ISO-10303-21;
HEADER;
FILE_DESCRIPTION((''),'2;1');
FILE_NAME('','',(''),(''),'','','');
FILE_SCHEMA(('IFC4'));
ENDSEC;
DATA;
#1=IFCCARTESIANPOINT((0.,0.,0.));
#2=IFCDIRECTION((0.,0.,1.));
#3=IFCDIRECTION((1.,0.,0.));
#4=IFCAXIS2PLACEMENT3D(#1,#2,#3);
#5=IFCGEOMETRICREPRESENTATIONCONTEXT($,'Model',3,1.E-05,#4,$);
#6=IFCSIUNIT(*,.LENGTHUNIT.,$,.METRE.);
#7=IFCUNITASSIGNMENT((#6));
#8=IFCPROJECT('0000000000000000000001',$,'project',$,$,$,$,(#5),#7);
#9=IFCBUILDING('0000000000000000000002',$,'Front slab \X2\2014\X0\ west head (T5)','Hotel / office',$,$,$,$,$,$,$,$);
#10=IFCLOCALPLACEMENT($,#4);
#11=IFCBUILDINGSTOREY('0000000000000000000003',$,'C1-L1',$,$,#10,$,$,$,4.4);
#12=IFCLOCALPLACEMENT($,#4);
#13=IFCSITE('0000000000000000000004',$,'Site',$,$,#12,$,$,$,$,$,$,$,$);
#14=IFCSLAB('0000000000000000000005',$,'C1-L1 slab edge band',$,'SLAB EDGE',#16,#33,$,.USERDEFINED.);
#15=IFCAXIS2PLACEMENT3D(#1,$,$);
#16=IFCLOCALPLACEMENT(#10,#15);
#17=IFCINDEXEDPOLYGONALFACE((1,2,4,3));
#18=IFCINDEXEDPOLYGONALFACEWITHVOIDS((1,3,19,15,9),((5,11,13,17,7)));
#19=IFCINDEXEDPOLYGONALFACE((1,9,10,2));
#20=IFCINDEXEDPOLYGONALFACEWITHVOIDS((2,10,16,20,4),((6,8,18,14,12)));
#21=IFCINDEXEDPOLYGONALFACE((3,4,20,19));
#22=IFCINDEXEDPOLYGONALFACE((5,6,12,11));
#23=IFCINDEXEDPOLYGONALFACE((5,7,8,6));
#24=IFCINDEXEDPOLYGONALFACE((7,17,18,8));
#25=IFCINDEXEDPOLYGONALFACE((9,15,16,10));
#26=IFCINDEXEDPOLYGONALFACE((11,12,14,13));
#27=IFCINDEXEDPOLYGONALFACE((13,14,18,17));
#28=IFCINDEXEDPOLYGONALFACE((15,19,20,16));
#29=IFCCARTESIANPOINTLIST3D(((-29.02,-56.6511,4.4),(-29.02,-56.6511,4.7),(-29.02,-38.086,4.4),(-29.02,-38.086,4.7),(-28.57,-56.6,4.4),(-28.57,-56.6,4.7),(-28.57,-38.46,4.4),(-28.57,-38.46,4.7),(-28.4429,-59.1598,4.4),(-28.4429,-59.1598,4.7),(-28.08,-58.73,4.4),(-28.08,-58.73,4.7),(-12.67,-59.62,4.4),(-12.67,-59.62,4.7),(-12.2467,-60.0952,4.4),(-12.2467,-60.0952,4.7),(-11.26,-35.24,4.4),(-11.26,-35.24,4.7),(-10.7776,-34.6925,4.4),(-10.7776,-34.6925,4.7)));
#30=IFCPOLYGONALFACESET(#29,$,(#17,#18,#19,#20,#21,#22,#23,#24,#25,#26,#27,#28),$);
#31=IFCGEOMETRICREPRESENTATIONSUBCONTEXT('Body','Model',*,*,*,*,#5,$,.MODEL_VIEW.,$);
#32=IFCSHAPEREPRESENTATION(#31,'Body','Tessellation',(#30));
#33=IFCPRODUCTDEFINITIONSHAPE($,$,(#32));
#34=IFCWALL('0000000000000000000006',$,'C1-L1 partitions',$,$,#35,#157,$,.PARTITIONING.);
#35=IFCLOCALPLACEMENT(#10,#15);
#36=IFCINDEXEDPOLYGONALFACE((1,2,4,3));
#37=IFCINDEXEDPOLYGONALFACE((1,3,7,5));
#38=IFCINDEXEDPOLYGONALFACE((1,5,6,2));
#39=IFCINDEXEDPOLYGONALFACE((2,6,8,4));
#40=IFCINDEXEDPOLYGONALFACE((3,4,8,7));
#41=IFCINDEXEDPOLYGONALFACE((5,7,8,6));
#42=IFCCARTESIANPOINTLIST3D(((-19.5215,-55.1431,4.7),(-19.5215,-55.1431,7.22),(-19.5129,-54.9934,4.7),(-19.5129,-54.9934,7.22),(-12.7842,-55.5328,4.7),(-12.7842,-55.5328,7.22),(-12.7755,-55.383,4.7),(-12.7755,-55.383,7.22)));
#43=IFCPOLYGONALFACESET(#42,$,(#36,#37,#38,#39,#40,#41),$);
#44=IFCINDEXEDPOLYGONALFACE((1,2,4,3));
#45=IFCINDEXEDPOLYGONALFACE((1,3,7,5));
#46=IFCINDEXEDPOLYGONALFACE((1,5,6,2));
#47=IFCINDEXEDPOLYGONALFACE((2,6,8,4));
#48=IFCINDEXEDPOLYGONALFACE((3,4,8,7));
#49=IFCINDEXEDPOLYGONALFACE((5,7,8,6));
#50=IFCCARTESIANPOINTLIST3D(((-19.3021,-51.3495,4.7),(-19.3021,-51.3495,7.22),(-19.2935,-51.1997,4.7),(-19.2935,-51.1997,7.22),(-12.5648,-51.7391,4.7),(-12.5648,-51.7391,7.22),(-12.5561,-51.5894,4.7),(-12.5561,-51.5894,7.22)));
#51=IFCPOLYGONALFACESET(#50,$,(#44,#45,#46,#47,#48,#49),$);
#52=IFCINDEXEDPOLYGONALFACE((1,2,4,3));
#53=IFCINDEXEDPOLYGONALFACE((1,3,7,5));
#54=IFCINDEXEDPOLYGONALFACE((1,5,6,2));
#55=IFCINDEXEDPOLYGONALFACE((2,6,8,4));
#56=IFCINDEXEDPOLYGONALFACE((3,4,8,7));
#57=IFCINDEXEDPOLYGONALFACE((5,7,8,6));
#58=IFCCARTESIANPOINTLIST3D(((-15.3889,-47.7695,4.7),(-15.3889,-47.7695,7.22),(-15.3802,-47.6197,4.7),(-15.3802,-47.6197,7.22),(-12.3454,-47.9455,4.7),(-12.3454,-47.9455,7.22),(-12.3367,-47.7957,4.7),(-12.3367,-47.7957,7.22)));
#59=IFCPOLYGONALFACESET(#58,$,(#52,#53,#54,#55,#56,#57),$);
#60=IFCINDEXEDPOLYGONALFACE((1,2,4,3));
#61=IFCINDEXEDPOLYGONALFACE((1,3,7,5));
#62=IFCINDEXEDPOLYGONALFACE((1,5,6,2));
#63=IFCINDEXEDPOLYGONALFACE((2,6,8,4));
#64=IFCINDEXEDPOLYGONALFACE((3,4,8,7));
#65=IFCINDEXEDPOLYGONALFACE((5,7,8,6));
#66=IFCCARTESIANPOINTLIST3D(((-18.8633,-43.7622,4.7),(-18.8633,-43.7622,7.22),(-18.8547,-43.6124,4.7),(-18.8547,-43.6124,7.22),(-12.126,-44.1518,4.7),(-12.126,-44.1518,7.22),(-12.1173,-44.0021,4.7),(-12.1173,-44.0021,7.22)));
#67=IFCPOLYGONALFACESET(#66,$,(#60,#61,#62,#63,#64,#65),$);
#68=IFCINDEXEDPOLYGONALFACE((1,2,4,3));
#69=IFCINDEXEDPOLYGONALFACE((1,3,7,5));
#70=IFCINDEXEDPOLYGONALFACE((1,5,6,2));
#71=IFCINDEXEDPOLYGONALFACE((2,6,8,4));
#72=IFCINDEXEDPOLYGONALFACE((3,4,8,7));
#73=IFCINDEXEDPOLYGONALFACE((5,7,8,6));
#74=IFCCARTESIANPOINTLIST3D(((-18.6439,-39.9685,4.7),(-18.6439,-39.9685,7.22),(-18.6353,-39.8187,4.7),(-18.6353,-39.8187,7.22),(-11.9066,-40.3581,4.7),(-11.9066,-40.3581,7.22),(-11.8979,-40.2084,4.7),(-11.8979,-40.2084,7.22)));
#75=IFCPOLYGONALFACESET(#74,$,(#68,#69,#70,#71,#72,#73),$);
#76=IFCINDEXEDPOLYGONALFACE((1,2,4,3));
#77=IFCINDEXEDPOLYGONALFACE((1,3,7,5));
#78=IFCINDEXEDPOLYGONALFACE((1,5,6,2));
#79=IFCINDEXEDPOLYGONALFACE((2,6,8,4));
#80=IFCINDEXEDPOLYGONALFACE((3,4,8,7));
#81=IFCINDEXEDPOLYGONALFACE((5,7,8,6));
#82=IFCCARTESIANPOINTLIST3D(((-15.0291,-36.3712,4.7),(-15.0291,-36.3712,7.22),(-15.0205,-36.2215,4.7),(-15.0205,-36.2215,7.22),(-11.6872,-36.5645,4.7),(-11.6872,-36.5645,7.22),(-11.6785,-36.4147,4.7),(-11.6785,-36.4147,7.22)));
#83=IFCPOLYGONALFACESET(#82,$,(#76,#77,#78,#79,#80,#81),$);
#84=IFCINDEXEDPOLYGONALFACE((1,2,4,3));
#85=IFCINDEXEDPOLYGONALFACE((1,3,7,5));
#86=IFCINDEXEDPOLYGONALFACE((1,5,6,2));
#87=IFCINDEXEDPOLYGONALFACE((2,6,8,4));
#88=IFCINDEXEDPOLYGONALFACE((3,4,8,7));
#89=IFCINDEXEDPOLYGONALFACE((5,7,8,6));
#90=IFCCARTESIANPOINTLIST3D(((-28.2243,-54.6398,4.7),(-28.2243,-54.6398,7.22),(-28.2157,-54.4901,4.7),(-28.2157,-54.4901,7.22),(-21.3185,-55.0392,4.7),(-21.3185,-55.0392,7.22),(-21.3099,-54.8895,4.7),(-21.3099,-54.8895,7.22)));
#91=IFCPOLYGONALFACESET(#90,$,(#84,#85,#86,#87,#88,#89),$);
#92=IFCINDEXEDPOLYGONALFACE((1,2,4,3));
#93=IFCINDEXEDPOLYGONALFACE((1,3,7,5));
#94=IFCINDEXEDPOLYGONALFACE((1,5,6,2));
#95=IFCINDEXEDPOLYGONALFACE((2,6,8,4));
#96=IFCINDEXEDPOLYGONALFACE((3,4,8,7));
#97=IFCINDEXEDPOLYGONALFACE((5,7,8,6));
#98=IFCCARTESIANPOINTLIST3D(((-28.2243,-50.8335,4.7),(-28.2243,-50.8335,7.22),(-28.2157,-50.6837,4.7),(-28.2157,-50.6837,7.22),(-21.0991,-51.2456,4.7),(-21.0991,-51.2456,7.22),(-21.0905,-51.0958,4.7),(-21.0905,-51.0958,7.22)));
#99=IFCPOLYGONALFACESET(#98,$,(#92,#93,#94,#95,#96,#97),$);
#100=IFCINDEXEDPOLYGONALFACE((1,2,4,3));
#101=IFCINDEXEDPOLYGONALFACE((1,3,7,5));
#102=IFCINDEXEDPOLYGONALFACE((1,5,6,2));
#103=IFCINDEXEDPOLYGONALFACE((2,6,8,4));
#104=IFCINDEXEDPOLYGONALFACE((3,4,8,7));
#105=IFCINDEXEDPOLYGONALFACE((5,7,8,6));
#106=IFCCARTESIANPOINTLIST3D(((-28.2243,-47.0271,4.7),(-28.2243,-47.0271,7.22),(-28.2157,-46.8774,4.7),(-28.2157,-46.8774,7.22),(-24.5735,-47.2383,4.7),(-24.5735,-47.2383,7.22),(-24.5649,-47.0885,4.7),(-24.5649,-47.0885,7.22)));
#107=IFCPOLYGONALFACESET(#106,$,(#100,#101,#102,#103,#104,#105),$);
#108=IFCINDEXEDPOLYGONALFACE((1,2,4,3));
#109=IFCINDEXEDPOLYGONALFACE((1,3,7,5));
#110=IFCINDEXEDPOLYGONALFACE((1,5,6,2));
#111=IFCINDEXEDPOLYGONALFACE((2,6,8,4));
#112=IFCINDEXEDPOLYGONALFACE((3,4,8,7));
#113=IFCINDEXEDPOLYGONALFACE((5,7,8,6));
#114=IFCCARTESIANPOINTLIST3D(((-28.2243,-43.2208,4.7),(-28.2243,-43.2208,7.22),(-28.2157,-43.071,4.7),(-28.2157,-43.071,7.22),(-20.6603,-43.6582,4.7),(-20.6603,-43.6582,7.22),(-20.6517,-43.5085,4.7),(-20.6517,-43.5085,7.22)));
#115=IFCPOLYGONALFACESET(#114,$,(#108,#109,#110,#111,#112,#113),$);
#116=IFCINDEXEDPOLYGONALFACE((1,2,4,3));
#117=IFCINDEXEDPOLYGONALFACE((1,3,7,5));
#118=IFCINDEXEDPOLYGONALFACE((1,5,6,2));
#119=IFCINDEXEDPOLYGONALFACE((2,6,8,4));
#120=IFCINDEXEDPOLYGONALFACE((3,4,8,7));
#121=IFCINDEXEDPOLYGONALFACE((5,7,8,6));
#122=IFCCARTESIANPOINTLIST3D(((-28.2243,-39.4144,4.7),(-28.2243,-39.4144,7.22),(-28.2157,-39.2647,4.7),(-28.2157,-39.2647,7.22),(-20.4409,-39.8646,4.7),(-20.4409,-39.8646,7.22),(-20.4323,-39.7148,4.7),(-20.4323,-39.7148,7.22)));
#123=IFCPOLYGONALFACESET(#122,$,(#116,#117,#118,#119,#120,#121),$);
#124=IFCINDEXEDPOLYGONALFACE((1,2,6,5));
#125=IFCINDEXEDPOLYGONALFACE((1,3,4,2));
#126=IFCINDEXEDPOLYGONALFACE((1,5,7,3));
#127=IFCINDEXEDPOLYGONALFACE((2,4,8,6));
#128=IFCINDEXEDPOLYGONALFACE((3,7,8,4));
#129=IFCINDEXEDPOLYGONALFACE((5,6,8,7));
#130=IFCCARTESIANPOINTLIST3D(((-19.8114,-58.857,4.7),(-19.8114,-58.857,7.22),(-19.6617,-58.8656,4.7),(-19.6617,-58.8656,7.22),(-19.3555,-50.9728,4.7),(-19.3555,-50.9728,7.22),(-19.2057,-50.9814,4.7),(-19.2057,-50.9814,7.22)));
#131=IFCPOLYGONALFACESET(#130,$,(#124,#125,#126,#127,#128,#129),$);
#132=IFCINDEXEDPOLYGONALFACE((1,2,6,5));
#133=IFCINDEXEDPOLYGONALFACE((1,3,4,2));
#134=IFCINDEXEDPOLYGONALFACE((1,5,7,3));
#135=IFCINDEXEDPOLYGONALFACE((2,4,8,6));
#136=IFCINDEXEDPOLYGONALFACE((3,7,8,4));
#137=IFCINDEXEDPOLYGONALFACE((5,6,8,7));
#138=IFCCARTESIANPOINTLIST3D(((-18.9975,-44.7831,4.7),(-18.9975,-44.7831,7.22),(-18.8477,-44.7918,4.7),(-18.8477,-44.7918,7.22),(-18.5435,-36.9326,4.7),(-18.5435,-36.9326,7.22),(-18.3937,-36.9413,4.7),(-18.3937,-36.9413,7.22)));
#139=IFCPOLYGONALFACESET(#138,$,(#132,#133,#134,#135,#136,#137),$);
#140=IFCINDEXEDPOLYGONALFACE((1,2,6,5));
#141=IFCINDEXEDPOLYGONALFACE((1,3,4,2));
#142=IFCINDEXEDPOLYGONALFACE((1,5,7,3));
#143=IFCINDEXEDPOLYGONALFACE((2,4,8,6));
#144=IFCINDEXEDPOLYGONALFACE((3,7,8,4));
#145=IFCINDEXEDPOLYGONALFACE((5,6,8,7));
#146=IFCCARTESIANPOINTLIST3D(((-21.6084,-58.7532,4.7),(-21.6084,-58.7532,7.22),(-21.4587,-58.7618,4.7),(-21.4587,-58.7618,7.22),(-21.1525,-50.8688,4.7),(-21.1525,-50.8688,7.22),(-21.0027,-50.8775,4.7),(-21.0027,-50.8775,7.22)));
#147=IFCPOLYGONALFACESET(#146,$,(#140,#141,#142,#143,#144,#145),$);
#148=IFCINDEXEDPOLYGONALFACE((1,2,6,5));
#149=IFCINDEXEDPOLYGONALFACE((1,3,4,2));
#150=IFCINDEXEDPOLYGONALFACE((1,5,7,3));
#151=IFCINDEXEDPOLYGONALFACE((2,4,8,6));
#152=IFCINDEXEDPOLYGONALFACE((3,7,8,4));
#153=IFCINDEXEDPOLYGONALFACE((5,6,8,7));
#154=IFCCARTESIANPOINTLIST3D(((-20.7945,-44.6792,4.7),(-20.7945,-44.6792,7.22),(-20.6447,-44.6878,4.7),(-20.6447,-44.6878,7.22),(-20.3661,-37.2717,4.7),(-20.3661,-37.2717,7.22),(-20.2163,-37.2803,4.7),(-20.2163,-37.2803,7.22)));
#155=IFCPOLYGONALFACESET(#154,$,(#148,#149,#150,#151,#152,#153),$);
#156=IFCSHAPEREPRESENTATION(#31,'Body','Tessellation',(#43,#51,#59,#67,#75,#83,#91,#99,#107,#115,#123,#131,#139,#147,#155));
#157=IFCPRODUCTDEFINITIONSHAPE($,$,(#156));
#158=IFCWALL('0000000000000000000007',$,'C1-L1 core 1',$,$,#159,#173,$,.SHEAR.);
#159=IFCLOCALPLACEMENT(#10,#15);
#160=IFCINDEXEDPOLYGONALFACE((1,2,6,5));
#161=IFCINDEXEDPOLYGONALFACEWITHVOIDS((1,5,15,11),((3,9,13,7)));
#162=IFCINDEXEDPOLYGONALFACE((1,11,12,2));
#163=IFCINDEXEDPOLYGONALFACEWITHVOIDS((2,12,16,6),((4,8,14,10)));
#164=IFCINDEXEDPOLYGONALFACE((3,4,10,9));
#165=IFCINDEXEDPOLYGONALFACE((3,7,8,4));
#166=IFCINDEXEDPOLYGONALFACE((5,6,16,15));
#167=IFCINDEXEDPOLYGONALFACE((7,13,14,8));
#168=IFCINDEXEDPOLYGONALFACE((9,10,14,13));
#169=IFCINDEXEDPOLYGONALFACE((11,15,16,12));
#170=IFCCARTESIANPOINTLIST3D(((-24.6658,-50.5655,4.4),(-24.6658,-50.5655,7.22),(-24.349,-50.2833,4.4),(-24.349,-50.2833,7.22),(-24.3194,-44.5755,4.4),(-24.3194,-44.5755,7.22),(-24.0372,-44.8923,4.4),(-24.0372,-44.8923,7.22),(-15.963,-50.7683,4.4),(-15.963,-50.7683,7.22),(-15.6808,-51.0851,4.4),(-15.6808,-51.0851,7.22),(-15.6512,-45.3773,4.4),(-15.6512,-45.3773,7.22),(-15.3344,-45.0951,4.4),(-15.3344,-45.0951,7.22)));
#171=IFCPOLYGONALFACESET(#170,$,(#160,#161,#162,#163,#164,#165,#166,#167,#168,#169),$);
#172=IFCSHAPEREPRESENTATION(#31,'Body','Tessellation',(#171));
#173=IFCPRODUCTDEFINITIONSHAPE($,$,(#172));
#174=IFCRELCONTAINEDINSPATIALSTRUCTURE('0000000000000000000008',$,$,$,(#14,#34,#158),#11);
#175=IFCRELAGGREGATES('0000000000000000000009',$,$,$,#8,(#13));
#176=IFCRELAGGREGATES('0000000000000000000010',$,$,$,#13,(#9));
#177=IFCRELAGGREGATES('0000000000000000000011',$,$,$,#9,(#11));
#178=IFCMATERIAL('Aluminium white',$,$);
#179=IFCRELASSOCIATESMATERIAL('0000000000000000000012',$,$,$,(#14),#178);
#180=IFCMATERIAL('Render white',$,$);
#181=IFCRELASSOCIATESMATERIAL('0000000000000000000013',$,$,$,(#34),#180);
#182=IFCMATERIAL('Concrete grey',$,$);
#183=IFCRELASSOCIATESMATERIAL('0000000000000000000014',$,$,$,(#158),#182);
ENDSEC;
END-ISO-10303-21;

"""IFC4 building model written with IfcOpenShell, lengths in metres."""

from ifc_helpers import new_model, si_unit, frame, origin_with_axes, place, context, subcontext, project, spatial, polyline, outline, extrude, material, element, save


model = new_model("IFC4")

# Units and contexts
model_context = context("Model", 3, precision=1e-05, world=origin_with_axes())
body_context = subcontext(model_context, "Body", "Model", "MODEL_VIEW")
ifc_project = project(units=[si_unit("LENGTHUNIT", "METRE")], contexts=[model_context])

# Site, building, storey
site_placement = place(None, origin_with_axes())
site = spatial("IfcSite", under=ifc_project, at=site_placement, Name="Site")
building = spatial("IfcBuilding", under=site, Name="Front slab — west head (T5)", Description="Hotel / office")
storey_placement = place(None, origin_with_axes())
storey = spatial("IfcBuildingStorey", under=building, at=storey_placement, Name="C1-L1", Elevation=4.4)

# Shared definitions
ifc_material_1 = material(Name="Aluminium white")

# Slab
slab_placement = place(storey_placement, origin_with_axes())
element("IfcSlab", 1, at=slab_placement, inside=storey, material=ifc_material_1, Name="C1-L1 slab edge band", ObjectType="SLAB EDGE", PredefinedType="USERDEFINED", context=body_context, shape_type="SweptSolid", body=[
    extrude(outline(polyline([(-10.7776, -34.6925), (-29.02, -38.086), (-29.02, -56.6511), (-28.4429, -59.1598), (-12.2467, -60.0952), (-10.7776, -34.6925)]), holes=[polyline([(-11.26, -35.24), (-28.57, -38.46), (-28.57, -56.6), (-28.08, -58.73), (-12.67, -59.62), (-11.26, -35.24)])]), frame((0.0, 0.0, 4.4), z_axis=(0.0, 0.0, 1.0), x_axis=(1.0, 0.0, 0.0)), (0.0, 0.0, 1.0), 0.3),
])

# Walls
ifc_material_2 = material(Name="Render white")
wall_1_placement = place(storey_placement, origin_with_axes())
element("IfcWall", 2, at=wall_1_placement, inside=storey, material=ifc_material_2, Name="C1-L1 partitions", PredefinedType="PARTITIONING", context=body_context, shape_type="SweptSolid", body=[
    extrude(outline(polyline([(-12.7755, -55.383), (-19.5129, -54.9934), (-19.5215, -55.1431), (-12.7842, -55.5328), (-12.7755, -55.383)])), frame((0.0, 0.0, 4.7), z_axis=(0.0, 0.0, 1.0), x_axis=(1.0, 0.0, 0.0)), (0.0, 0.0, 1.0), 2.52),
    extrude(outline(polyline([(-12.5561, -51.5894), (-19.2935, -51.1997), (-19.3021, -51.3495), (-12.5648, -51.7391), (-12.5561, -51.5894)])), frame((0.0, 0.0, 4.7), z_axis=(0.0, 0.0, 1.0), x_axis=(1.0, 0.0, 0.0)), (0.0, 0.0, 1.0), 2.52),
    extrude(outline(polyline([(-12.3367, -47.7957), (-15.3802, -47.6197), (-15.3889, -47.7695), (-12.3454, -47.9455), (-12.3367, -47.7957)])), frame((0.0, 0.0, 4.7), z_axis=(0.0, 0.0, 1.0), x_axis=(1.0, 0.0, 0.0)), (0.0, 0.0, 1.0), 2.52),
    extrude(outline(polyline([(-12.1173, -44.0021), (-18.8547, -43.6124), (-18.8633, -43.7622), (-12.126, -44.1518), (-12.1173, -44.0021)])), frame((0.0, 0.0, 4.7), z_axis=(0.0, 0.0, 1.0), x_axis=(1.0, 0.0, 0.0)), (0.0, 0.0, 1.0), 2.52),
    extrude(outline(polyline([(-11.8979, -40.2084), (-18.6353, -39.8187), (-18.6439, -39.9685), (-11.9066, -40.3581), (-11.8979, -40.2084)])), frame((0.0, 0.0, 4.7), z_axis=(0.0, 0.0, 1.0), x_axis=(1.0, 0.0, 0.0)), (0.0, 0.0, 1.0), 2.52),
    extrude(outline(polyline([(-11.6785, -36.4147), (-15.0205, -36.2215), (-15.0291, -36.3712), (-11.6872, -36.5645), (-11.6785, -36.4147)])), frame((0.0, 0.0, 4.7), z_axis=(0.0, 0.0, 1.0), x_axis=(1.0, 0.0, 0.0)), (0.0, 0.0, 1.0), 2.52),
    extrude(outline(polyline([(-21.3099, -54.8895), (-28.2157, -54.4901), (-28.2243, -54.6398), (-21.3185, -55.0392), (-21.3099, -54.8895)])), frame((0.0, 0.0, 4.7), z_axis=(0.0, 0.0, 1.0), x_axis=(1.0, 0.0, 0.0)), (0.0, 0.0, 1.0), 2.52),
    extrude(outline(polyline([(-21.0905, -51.0958), (-28.2157, -50.6837), (-28.2243, -50.8335), (-21.0991, -51.2456), (-21.0905, -51.0958)])), frame((0.0, 0.0, 4.7), z_axis=(0.0, 0.0, 1.0), x_axis=(1.0, 0.0, 0.0)), (0.0, 0.0, 1.0), 2.52),
    extrude(outline(polyline([(-24.5649, -47.0885), (-28.2157, -46.8774), (-28.2243, -47.0271), (-24.5735, -47.2383), (-24.5649, -47.0885)])), frame((0.0, 0.0, 4.7), z_axis=(0.0, 0.0, 1.0), x_axis=(1.0, 0.0, 0.0)), (0.0, 0.0, 1.0), 2.52),
    extrude(outline(polyline([(-20.6517, -43.5085), (-28.2157, -43.071), (-28.2243, -43.2208), (-20.6603, -43.6582), (-20.6517, -43.5085)])), frame((0.0, 0.0, 4.7), z_axis=(0.0, 0.0, 1.0), x_axis=(1.0, 0.0, 0.0)), (0.0, 0.0, 1.0), 2.52),
    extrude(outline(polyline([(-20.4323, -39.7148), (-28.2157, -39.2647), (-28.2243, -39.4144), (-20.4409, -39.8646), (-20.4323, -39.7148)])), frame((0.0, 0.0, 4.7), z_axis=(0.0, 0.0, 1.0), x_axis=(1.0, 0.0, 0.0)), (0.0, 0.0, 1.0), 2.52),
    extrude(outline(polyline([(-19.6617, -58.8656), (-19.2057, -50.9814), (-19.3555, -50.9728), (-19.8114, -58.857), (-19.6617, -58.8656)])), frame((0.0, 0.0, 4.7), z_axis=(0.0, 0.0, 1.0), x_axis=(1.0, 0.0, 0.0)), (0.0, 0.0, 1.0), 2.52),
    extrude(outline(polyline([(-18.8477, -44.7918), (-18.3937, -36.9413), (-18.5435, -36.9326), (-18.9975, -44.7831), (-18.8477, -44.7918)])), frame((0.0, 0.0, 4.7), z_axis=(0.0, 0.0, 1.0), x_axis=(1.0, 0.0, 0.0)), (0.0, 0.0, 1.0), 2.52),
    extrude(outline(polyline([(-21.4587, -58.7618), (-21.0027, -50.8775), (-21.1525, -50.8688), (-21.6084, -58.7532), (-21.4587, -58.7618)])), frame((0.0, 0.0, 4.7), z_axis=(0.0, 0.0, 1.0), x_axis=(1.0, 0.0, 0.0)), (0.0, 0.0, 1.0), 2.52),
    extrude(outline(polyline([(-20.6447, -44.6878), (-20.2163, -37.2803), (-20.3661, -37.2717), (-20.7945, -44.6792), (-20.6447, -44.6878)])), frame((0.0, 0.0, 4.7), z_axis=(0.0, 0.0, 1.0), x_axis=(1.0, 0.0, 0.0)), (0.0, 0.0, 1.0), 2.52),
])
ifc_material_3 = material(Name="Concrete grey")
wall_2_placement = place(storey_placement, origin_with_axes())
element("IfcWall", 3, at=wall_2_placement, inside=storey, material=ifc_material_3, Name="C1-L1 core 1", PredefinedType="SHEAR", context=body_context, shape_type="SweptSolid", body=[
    extrude(outline(polyline([(-15.6808, -51.0851), (-15.3344, -45.0951), (-24.3194, -44.5755), (-24.6658, -50.5655), (-15.6808, -51.0851)]), holes=[polyline([(-15.963, -50.7683), (-15.6512, -45.3773), (-24.0372, -44.8923), (-24.349, -50.2833), (-15.963, -50.7683)])]), frame((0.0, 0.0, 4.4), z_axis=(0.0, 0.0, 1.0), x_axis=(1.0, 0.0, 0.0)), (0.0, 0.0, 1.0), 2.82),
])

save(model, "model.ifc")
